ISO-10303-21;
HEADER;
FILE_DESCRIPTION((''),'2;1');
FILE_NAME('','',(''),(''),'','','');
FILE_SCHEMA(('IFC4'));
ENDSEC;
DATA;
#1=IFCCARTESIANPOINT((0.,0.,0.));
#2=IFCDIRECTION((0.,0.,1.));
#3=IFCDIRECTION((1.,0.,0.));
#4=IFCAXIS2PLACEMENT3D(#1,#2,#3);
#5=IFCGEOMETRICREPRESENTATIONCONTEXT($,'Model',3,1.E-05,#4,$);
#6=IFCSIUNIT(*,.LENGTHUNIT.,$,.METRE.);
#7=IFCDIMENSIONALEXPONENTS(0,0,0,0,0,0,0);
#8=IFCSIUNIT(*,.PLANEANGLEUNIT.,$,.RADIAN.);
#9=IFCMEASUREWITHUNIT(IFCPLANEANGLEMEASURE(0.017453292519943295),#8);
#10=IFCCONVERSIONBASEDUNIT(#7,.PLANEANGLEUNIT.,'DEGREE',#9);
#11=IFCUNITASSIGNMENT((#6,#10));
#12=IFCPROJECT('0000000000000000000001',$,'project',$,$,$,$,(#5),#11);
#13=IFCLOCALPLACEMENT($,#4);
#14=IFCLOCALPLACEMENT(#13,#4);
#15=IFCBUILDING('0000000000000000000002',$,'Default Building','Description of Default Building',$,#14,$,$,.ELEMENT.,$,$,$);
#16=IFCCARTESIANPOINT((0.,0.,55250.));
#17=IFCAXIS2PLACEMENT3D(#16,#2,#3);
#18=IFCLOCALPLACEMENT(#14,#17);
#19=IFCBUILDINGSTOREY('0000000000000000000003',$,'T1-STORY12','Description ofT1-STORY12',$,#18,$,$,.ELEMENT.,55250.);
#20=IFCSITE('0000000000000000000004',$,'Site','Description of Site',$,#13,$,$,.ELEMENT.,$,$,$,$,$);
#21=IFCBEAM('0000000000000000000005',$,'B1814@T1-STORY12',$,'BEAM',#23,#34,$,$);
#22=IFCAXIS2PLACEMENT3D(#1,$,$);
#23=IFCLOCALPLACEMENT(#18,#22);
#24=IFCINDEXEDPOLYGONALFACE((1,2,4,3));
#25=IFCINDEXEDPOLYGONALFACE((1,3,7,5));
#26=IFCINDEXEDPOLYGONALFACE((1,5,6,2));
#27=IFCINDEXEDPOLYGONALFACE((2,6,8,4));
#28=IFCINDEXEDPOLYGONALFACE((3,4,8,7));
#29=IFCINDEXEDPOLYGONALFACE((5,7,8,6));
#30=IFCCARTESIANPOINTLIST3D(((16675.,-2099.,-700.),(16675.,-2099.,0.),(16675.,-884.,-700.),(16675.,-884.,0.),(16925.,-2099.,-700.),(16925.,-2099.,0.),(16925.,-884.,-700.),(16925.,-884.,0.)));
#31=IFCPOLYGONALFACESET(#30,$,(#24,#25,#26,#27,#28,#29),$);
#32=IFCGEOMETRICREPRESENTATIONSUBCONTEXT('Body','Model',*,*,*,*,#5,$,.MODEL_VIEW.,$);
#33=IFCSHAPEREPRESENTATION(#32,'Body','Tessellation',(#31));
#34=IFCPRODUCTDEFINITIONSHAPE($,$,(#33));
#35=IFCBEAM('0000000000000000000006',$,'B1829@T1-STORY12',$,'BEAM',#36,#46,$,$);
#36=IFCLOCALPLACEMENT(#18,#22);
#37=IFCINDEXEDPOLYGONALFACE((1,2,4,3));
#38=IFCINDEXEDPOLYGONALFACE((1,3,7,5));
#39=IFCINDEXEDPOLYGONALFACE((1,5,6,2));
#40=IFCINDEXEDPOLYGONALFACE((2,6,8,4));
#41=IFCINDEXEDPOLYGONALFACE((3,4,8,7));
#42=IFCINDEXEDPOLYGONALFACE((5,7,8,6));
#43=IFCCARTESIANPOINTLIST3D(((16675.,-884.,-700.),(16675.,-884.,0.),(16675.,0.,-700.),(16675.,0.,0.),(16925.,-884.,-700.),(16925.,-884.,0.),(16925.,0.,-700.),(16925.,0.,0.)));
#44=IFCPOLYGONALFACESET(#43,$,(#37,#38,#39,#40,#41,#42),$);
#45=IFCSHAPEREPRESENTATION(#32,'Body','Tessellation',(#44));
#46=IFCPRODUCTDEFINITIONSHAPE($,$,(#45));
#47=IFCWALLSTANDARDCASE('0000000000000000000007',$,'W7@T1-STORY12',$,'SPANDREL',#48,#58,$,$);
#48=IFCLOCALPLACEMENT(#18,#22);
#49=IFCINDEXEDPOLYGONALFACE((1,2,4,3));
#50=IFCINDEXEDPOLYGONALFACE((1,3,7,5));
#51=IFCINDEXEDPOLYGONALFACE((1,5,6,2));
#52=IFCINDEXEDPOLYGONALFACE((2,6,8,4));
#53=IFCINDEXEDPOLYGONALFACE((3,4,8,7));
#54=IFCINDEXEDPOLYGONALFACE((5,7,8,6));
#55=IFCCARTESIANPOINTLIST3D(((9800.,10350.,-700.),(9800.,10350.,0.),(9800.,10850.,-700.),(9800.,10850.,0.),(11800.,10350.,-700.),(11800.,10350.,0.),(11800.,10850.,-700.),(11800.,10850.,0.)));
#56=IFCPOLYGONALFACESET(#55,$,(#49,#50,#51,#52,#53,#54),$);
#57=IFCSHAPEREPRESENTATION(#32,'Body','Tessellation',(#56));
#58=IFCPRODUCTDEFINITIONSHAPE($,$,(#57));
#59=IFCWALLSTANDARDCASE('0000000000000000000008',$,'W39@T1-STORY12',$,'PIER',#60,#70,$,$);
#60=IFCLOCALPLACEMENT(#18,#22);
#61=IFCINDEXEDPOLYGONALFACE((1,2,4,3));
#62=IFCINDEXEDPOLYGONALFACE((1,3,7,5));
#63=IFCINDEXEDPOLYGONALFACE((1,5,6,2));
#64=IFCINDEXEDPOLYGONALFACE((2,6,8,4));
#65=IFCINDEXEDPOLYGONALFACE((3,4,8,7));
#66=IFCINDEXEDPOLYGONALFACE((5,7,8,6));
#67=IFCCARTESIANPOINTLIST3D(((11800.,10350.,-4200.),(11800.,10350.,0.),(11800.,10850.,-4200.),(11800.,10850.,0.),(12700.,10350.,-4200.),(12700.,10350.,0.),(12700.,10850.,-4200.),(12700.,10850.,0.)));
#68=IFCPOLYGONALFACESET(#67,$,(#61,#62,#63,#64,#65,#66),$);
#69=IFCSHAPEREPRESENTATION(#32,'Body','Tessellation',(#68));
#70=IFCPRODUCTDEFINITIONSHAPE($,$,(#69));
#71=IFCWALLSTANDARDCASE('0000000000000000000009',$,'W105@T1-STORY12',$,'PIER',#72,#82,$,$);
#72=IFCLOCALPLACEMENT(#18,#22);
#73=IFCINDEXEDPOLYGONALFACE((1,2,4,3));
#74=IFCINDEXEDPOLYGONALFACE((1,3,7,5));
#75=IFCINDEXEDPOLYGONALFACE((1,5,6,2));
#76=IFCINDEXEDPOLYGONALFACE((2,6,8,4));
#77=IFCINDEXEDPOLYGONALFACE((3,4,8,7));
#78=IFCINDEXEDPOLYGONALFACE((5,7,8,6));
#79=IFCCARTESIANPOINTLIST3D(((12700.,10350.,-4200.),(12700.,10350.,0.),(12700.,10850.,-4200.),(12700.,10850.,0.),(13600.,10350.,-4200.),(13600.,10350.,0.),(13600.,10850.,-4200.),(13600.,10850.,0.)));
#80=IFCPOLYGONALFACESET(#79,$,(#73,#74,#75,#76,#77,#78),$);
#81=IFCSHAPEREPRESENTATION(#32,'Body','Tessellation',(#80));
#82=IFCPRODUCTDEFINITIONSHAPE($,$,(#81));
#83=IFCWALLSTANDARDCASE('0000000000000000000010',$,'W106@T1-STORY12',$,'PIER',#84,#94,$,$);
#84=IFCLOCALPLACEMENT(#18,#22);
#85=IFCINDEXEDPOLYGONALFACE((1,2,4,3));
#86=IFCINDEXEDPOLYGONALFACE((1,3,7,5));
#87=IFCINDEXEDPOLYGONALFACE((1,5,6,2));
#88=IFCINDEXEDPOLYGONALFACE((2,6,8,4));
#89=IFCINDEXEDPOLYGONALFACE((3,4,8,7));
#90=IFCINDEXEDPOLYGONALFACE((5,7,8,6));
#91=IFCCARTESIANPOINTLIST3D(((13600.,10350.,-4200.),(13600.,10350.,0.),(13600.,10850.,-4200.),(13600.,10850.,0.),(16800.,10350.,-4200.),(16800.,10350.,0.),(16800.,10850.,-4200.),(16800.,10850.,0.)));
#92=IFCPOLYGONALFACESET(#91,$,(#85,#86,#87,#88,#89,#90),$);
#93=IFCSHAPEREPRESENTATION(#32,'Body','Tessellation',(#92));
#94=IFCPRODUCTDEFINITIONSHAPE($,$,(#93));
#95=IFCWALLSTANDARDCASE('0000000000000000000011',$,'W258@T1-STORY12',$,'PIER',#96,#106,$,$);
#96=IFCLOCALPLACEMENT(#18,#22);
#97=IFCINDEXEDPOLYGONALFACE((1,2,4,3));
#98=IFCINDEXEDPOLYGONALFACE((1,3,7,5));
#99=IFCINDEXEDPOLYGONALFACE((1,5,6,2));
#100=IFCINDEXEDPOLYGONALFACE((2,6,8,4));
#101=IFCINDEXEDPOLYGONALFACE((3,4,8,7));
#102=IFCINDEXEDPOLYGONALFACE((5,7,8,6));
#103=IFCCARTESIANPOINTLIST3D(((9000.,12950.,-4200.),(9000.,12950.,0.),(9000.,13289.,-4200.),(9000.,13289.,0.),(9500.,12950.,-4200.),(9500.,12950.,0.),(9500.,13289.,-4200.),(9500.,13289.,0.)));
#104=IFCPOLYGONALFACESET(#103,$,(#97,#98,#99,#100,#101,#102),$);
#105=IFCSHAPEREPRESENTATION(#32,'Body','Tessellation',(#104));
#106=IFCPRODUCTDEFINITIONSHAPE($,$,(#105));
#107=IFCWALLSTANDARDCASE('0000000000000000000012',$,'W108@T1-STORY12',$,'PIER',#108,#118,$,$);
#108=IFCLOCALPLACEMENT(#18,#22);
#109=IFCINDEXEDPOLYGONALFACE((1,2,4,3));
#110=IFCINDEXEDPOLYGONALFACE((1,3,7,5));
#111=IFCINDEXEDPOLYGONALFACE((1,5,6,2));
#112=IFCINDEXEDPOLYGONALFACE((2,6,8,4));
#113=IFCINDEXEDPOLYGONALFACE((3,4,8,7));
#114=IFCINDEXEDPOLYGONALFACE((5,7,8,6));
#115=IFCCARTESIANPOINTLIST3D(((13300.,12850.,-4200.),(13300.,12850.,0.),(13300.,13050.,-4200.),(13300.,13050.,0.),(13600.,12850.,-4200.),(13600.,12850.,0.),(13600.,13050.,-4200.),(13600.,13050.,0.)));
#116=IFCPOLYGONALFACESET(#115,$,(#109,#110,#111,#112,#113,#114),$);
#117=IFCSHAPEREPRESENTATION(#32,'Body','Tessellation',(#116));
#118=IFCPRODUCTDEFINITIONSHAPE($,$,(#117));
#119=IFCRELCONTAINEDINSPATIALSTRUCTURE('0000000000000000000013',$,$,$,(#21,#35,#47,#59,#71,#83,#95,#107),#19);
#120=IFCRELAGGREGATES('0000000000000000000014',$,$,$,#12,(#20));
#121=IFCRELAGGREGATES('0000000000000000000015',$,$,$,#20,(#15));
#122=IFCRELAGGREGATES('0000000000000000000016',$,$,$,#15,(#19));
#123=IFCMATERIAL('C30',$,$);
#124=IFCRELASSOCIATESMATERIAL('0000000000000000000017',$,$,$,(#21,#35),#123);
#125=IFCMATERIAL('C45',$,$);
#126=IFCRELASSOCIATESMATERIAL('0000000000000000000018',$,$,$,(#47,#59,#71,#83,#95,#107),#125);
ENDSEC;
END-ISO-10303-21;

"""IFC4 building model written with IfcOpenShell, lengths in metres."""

from ifc_helpers import new_model, entity, si_unit, converted_unit, frame, origin_with_axes, place, context, subcontext, project, spatial, indexed_curve, rectangle, outline, extrude, material, element, save


model = new_model("IFC4")

# Units and contexts
model_context = context("Model", 3, precision=1e-05, world=origin_with_axes())
body_context = subcontext(model_context, "Body", "Model", "MODEL_VIEW")
ifc_project = project(units=[si_unit("LENGTHUNIT", "METRE"), converted_unit("PLANEANGLEUNIT", "DEGREE", entity("IfcPlaneAngleMeasure", 0.017453292519943295), si_unit("PLANEANGLEUNIT", "RADIAN"), dimensions=[0, 0, 0, 0, 0, 0, 0])], contexts=[model_context])

# Site, building, storey
site_placement = place(None, origin_with_axes())
site = spatial("IfcSite", under=ifc_project, at=site_placement, Name="Site", Description="Description of Site", CompositionType="ELEMENT")
building_placement = place(site_placement, origin_with_axes())
building = spatial("IfcBuilding", under=site, at=building_placement, Name="Default Building", Description="Description of Default Building", CompositionType="ELEMENT")
storey_placement = place(building_placement, frame((0.0, 0.0, 55250.0), z_axis=(0.0, 0.0, 1.0), x_axis=(1.0, 0.0, 0.0)))
storey = spatial("IfcBuildingStorey", under=building, at=storey_placement, Name="T1-STORY12", Description="Description ofT1-STORY12", CompositionType="ELEMENT", Elevation=55250.0)

# Beams
ifc_material_1 = material(Name="C30")
beam_1_placement = place(storey_placement, frame((16800.0, -2099.0, -350.0), z_axis=(0.0, 1.0, 0.0), x_axis=(-1.0, 0.0, 0.0)))
element("IfcBeam", 1, at=beam_1_placement, inside=storey, material=ifc_material_1, Name="B1814@T1-STORY12", ObjectType="BEAM", context=body_context, shape_type="SweptSolid", body=[
    extrude(rectangle(XDim=250.0, YDim=700.0), origin_with_axes(), (0.0, 0.0, 1.0), 1215.0),
])
beam_2_placement = place(storey_placement, frame((16800.0, -884.0, -350.0), z_axis=(0.0, 1.0, 0.0), x_axis=(-1.0, 0.0, 0.0)))
element("IfcBeam", 2, at=beam_2_placement, inside=storey, material=ifc_material_1, Name="B1829@T1-STORY12", ObjectType="BEAM", context=body_context, shape_type="SweptSolid", body=[
    extrude(rectangle(XDim=250.0, YDim=700.0), origin_with_axes(), (0.0, 0.0, 1.0), 884.0),
])
ifc_material_2 = material(Name="C45")

# Walls
wall_1_placement = place(storey_placement, frame((9800.0, 10600.0, -700.0), z_axis=(0.0, 0.0, 1.0), x_axis=(1.0, 0.0, 0.0)))
element("IfcWallStandardCase", 3, at=wall_1_placement, inside=storey, material=ifc_material_2, Name="W7@T1-STORY12", ObjectType="SPANDREL", context=body_context, shape_type="SweptSolid", body=[
    extrude(outline(indexed_curve([(0.0, -250.0), (0.0, 250.0), (2000.0, 250.0), (2000.0, -250.0), (0.0, -250.0)], self_intersect=False)), origin_with_axes(), (0.0, 0.0, 1.0), 700.0),
])
for number, where, z_axis, x_axis, name in (
    (4, (11800.0, 10600.0, -4200.0), (0.0, 0.0, 1.0), (1.0, 0.0, 0.0), "W39@T1-STORY12"),
    (5, (12700.0, 10600.0, -4200.0), (0.0, 0.0, 1.0), (1.0, 0.0, 0.0), "W105@T1-STORY12"),
):
    element("IfcWallStandardCase", number, at=place(storey_placement, frame(where, z_axis=z_axis, x_axis=x_axis)), inside=storey, material=ifc_material_2, Name=name, ObjectType="PIER", context=body_context, shape_type="SweptSolid", body=[
        extrude(outline(indexed_curve([(0.0, -250.0), (0.0, 250.0), (900.0, 250.0), (900.0, -250.0), (0.0, -250.0)], self_intersect=False)), origin_with_axes(), (0.0, 0.0, 1.0), 4200.0),
    ])
wall_2_placement = place(storey_placement, frame((13600.0, 10600.0, -4200.0), z_axis=(0.0, 0.0, 1.0), x_axis=(1.0, 0.0, 0.0)))
element("IfcWallStandardCase", 6, at=wall_2_placement, inside=storey, material=ifc_material_2, Name="W106@T1-STORY12", ObjectType="PIER", context=body_context, shape_type="SweptSolid", body=[
    extrude(outline(indexed_curve([(0.0, -250.0), (0.0, 250.0), (3200.0, 250.0), (3200.0, -250.0), (0.0, -250.0)], self_intersect=False)), origin_with_axes(), (0.0, 0.0, 1.0), 4200.0),
])
wall_3_placement = place(storey_placement, frame((9250.0, 12950.0, -4200.0), z_axis=(0.0, 0.0, 1.0), x_axis=(0.0, 1.0, 0.0)))
element("IfcWallStandardCase", 7, at=wall_3_placement, inside=storey, material=ifc_material_2, Name="W258@T1-STORY12", ObjectType="PIER", context=body_context, shape_type="SweptSolid", body=[
    extrude(outline(indexed_curve([(0.0, -250.0), (0.0, 250.0), (339.0, 250.0), (339.0, -250.0), (0.0, -250.0)], self_intersect=False)), origin_with_axes(), (0.0, 0.0, 1.0), 4200.0),
])
wall_4_placement = place(storey_placement, frame((13300.0, 12950.0, -4200.0), z_axis=(0.0, 0.0, 1.0), x_axis=(1.0, 0.0, 0.0)))
element("IfcWallStandardCase", 8, at=wall_4_placement, inside=storey, material=ifc_material_2, Name="W108@T1-STORY12", ObjectType="PIER", context=body_context, shape_type="SweptSolid", body=[
    extrude(outline(indexed_curve([(0.0, -100.0), (0.0, 100.0), (300.0, 100.0), (300.0, -100.0), (0.0, -100.0)], self_intersect=False)), origin_with_axes(), (0.0, 0.0, 1.0), 4200.0),
])

save(model, "model.ifc")
